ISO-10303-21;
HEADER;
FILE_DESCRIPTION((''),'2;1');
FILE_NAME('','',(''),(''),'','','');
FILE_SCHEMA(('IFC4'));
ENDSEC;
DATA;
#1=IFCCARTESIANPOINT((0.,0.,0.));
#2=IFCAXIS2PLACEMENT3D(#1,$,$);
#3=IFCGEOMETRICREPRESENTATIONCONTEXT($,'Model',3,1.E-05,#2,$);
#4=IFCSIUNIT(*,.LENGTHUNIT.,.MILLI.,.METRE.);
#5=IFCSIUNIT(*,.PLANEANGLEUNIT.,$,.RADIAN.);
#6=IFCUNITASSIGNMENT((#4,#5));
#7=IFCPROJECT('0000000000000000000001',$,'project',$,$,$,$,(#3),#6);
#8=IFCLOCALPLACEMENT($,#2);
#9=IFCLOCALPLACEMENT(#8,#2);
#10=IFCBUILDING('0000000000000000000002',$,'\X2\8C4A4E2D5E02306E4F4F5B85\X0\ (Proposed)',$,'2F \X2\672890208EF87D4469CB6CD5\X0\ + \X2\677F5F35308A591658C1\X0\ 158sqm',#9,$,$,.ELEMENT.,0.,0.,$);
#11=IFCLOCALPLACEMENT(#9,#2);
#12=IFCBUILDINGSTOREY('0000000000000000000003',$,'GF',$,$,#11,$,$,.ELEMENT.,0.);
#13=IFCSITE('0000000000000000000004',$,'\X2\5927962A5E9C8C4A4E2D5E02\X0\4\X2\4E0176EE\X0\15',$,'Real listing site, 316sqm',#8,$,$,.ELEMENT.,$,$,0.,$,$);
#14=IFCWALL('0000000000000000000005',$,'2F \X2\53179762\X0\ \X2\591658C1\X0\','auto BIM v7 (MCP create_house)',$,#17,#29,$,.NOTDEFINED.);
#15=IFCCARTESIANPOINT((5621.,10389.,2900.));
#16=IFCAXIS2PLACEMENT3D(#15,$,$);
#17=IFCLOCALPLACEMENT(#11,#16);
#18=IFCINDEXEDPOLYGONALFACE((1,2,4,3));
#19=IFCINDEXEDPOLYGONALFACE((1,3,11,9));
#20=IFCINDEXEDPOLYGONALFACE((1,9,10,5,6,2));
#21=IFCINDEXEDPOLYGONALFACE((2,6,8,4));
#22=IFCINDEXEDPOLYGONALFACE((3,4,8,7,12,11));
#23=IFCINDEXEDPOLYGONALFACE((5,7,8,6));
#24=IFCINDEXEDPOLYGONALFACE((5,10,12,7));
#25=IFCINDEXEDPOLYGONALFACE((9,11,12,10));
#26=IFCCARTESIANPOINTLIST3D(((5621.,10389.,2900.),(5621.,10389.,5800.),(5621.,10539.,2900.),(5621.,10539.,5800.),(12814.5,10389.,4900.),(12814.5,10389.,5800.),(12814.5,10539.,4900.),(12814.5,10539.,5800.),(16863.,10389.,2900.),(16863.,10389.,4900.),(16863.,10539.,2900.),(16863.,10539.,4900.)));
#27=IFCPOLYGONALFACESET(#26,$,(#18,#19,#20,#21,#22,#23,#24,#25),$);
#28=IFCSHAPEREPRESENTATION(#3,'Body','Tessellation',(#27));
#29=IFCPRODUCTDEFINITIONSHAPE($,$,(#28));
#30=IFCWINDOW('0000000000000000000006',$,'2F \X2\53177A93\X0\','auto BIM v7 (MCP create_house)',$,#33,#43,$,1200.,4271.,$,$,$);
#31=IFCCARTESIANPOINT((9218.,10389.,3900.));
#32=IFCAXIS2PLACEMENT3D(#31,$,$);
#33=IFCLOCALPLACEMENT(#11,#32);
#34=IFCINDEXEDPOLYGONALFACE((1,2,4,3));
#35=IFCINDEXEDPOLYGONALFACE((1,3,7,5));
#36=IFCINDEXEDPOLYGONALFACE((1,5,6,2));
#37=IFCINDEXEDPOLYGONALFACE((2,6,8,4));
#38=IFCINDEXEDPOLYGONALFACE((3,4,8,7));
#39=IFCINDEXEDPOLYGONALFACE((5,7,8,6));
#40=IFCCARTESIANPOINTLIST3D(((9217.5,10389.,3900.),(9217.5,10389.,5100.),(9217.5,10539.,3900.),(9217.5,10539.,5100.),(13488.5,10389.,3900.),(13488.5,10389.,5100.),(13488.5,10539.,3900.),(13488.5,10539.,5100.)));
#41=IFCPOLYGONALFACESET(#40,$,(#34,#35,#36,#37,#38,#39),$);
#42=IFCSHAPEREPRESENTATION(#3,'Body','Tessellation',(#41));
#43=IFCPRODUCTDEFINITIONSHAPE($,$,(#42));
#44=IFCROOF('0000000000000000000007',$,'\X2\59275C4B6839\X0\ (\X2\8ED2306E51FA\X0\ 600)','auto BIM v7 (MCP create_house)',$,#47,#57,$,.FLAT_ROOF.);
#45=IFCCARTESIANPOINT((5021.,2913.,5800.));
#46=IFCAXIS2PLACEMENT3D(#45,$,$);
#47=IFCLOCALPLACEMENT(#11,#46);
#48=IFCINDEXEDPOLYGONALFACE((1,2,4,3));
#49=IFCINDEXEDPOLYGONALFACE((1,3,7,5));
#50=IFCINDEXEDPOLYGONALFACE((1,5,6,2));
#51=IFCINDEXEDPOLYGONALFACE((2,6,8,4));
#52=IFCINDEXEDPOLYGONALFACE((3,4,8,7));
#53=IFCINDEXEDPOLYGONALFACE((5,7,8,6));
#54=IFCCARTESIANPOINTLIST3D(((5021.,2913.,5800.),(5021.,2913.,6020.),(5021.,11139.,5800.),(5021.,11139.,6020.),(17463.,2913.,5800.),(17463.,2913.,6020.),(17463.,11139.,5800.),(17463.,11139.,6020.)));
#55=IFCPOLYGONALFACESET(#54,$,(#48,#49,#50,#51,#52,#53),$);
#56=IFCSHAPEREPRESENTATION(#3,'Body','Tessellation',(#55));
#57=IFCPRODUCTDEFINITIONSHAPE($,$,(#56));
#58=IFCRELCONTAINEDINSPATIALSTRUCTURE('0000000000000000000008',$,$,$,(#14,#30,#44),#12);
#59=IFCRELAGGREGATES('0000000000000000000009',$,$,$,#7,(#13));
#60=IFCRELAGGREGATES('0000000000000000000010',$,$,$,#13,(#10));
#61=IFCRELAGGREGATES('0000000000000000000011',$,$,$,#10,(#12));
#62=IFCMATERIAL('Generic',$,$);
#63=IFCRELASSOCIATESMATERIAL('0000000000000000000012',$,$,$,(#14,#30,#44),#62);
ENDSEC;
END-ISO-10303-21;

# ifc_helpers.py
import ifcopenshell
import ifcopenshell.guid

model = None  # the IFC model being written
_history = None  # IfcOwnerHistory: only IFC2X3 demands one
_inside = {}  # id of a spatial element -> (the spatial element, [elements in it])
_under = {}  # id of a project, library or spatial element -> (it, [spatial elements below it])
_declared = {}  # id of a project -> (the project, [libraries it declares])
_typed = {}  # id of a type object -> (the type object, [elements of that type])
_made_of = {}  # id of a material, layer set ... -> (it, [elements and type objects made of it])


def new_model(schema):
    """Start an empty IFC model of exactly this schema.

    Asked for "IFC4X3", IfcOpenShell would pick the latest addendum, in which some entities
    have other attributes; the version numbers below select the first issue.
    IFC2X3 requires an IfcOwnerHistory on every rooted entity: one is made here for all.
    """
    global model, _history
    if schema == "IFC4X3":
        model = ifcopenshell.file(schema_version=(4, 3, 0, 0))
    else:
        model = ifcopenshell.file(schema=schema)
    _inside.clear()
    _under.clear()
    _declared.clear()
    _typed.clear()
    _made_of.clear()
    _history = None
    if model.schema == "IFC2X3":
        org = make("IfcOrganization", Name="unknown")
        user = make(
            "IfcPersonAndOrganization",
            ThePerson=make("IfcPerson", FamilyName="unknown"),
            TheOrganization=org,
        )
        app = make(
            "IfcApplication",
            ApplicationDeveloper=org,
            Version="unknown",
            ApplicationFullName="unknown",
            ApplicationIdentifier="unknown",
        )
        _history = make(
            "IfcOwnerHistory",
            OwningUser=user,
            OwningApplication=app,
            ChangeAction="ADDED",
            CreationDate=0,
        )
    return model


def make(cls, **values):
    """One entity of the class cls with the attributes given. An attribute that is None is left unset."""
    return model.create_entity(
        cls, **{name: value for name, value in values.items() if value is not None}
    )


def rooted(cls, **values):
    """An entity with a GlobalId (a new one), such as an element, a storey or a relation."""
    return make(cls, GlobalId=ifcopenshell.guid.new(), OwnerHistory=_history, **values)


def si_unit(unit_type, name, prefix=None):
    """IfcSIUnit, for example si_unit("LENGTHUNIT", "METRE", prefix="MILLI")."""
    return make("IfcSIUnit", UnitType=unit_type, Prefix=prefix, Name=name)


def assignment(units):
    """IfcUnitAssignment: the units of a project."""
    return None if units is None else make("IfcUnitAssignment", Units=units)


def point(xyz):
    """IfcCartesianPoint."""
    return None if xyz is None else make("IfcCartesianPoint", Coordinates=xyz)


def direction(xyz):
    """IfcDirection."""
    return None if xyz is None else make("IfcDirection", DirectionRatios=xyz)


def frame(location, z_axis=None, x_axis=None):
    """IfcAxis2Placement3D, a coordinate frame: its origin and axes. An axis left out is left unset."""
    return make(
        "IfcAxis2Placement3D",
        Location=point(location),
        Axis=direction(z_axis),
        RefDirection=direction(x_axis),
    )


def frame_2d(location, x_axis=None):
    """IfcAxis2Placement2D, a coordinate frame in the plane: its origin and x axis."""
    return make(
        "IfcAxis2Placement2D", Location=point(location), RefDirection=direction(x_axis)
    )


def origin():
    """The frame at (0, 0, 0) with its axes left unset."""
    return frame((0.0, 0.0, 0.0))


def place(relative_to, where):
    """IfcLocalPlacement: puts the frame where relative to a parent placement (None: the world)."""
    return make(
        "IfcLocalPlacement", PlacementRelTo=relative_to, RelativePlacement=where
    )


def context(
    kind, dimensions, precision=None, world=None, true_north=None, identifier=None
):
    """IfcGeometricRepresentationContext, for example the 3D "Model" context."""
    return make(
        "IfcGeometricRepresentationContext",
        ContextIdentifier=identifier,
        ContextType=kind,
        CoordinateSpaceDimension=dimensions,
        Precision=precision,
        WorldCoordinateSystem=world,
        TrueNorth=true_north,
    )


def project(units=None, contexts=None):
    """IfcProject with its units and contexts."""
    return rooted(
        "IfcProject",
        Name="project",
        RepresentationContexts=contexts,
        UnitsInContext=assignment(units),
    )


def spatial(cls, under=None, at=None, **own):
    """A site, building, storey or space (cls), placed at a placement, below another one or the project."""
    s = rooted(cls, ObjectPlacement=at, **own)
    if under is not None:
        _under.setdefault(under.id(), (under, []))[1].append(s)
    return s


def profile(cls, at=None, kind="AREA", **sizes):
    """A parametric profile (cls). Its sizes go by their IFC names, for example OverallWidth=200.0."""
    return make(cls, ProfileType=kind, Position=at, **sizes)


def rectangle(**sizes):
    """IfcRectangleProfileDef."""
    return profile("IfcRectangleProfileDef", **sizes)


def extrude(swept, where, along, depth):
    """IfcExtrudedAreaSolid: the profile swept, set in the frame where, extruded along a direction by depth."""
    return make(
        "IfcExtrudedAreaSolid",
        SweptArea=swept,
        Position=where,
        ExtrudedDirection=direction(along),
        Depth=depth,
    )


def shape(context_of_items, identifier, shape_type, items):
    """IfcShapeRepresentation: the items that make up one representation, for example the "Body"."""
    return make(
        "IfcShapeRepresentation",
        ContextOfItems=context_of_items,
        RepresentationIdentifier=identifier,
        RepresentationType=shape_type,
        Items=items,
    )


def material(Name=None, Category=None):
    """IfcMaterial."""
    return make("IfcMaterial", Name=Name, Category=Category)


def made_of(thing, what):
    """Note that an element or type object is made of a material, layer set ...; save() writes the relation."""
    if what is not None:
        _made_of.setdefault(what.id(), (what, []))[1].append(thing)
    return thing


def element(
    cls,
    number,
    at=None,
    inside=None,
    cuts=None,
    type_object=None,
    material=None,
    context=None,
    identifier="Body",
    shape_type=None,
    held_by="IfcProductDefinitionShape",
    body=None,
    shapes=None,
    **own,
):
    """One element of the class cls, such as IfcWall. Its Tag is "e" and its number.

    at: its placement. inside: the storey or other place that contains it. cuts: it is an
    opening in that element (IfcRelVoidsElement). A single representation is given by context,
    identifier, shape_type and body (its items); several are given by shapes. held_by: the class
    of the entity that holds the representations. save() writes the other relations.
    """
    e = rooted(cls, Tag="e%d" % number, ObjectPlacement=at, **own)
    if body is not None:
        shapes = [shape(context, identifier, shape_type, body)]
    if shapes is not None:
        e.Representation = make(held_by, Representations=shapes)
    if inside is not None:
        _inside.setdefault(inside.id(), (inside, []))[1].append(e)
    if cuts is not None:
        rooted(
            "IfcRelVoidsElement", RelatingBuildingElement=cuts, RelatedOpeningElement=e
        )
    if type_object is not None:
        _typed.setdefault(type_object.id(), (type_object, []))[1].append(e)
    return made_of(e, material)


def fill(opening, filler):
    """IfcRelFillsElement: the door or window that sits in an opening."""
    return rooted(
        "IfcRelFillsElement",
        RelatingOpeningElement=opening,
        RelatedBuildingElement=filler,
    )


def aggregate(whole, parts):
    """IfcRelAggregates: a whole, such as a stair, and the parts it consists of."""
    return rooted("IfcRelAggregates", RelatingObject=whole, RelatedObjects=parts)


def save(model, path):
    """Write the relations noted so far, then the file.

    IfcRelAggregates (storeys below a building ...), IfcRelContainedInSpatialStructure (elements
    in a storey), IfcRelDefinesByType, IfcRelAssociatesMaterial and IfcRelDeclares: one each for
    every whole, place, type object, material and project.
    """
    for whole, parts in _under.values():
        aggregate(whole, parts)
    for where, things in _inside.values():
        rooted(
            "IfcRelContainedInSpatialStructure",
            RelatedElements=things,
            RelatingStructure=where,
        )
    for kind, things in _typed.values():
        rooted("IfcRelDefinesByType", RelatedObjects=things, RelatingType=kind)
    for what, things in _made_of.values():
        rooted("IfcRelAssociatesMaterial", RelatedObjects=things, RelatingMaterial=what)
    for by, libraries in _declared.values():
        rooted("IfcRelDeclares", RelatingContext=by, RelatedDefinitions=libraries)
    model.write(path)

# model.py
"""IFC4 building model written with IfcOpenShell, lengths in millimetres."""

from ifc_helpers import new_model, si_unit, frame, frame_2d, origin, place, context, project, spatial, rectangle, extrude, material, element, fill, save


model = new_model("IFC4")

# Units and contexts
model_context = context("Model", 3, precision=1e-05, world=origin())
ifc_project = project(units=[si_unit("LENGTHUNIT", "METRE", prefix="MILLI"), si_unit("PLANEANGLEUNIT", "RADIAN")], contexts=[model_context])

# Site, building, storey
site_placement = place(None, origin())
site = spatial("IfcSite", under=ifc_project, at=site_placement, Name="大阪府豊中市4丁目15", ObjectType="Real listing site, 316sqm", CompositionType="ELEMENT", RefElevation=0.0)
building_placement = place(site_placement, origin())
building = spatial("IfcBuilding", under=site, at=building_placement, Name="豊中市の住宅 (Proposed)", ObjectType="2F 木造軸組構法 + 板張り外壁 158sqm", CompositionType="ELEMENT", ElevationOfRefHeight=0.0, ElevationOfTerrain=0.0)
storey_placement = place(building_placement, origin())
storey = spatial("IfcBuildingStorey", under=building, at=storey_placement, Name="GF", CompositionType="ELEMENT", Elevation=0.0)

# Shared definitions
ifc_material = material(Name="Generic")

# Wall, opening, window
wall_1_placement = place(storey_placement, frame((5621.0, 10389.0, 2900.0)))
wall_1 = element("IfcWall", 1, at=wall_1_placement, inside=storey, material=ifc_material, Name="2F 北面 外壁", Description="auto BIM v7 (MCP create_house)", PredefinedType="NOTDEFINED", context=model_context, shape_type="SweptSolid", body=[
    extrude(rectangle(XDim=11242.0, YDim=150.0, at=frame_2d((5621.0, 75.0))), frame((5621.0, 10389.0, 2900.0)), (0.0, 0.0, 1.0), 2900.0),
])
opening_1_placement = place(storey_placement, frame((9218.0, 10389.0, 3900.0)))
opening_1 = element("IfcOpeningElement", 2, at=opening_1_placement, cuts=wall_1, PredefinedType="NOTDEFINED", context=model_context, shape_type="SweptSolid", body=[
    extrude(rectangle(XDim=4271.0, YDim=150.0, at=frame_2d((2135.0, 75.0))), frame((9218.0, 10389.0, 3900.0)), (0.0, 0.0, 1.0), 1200.0),
])
window_1_placement = place(storey_placement, frame((9218.0, 10389.0, 3900.0)))
window_1 = element("IfcWindow", 3, at=window_1_placement, inside=storey, material=ifc_material, Name="2F 北窓", Description="auto BIM v7 (MCP create_house)", OverallHeight=1200.0, OverallWidth=4271.0, context=model_context, shape_type="SweptSolid", body=[
    extrude(rectangle(XDim=4271.0, YDim=150.0, at=frame_2d((2135.0, 75.0))), frame((9218.0, 10389.0, 3900.0)), (0.0, 0.0, 1.0), 1200.0),
])
fill(opening_1, window_1)

# Roof
roof_placement = place(storey_placement, frame((5021.0, 2913.0, 5800.0)))
element("IfcRoof", 4, at=roof_placement, inside=storey, material=ifc_material, Name="大屋根 (軒の出 600)", Description="auto BIM v7 (MCP create_house)", PredefinedType="FLAT_ROOF", context=model_context, shape_type="SweptSolid", body=[
    extrude(rectangle(XDim=12442.0, YDim=8226.0, at=frame_2d((6221.0, 4113.0))), frame((5021.0, 2913.0, 5800.0)), (0.0, 0.0, 1.0), 220.0),
])

save(model, "model.ifc")
